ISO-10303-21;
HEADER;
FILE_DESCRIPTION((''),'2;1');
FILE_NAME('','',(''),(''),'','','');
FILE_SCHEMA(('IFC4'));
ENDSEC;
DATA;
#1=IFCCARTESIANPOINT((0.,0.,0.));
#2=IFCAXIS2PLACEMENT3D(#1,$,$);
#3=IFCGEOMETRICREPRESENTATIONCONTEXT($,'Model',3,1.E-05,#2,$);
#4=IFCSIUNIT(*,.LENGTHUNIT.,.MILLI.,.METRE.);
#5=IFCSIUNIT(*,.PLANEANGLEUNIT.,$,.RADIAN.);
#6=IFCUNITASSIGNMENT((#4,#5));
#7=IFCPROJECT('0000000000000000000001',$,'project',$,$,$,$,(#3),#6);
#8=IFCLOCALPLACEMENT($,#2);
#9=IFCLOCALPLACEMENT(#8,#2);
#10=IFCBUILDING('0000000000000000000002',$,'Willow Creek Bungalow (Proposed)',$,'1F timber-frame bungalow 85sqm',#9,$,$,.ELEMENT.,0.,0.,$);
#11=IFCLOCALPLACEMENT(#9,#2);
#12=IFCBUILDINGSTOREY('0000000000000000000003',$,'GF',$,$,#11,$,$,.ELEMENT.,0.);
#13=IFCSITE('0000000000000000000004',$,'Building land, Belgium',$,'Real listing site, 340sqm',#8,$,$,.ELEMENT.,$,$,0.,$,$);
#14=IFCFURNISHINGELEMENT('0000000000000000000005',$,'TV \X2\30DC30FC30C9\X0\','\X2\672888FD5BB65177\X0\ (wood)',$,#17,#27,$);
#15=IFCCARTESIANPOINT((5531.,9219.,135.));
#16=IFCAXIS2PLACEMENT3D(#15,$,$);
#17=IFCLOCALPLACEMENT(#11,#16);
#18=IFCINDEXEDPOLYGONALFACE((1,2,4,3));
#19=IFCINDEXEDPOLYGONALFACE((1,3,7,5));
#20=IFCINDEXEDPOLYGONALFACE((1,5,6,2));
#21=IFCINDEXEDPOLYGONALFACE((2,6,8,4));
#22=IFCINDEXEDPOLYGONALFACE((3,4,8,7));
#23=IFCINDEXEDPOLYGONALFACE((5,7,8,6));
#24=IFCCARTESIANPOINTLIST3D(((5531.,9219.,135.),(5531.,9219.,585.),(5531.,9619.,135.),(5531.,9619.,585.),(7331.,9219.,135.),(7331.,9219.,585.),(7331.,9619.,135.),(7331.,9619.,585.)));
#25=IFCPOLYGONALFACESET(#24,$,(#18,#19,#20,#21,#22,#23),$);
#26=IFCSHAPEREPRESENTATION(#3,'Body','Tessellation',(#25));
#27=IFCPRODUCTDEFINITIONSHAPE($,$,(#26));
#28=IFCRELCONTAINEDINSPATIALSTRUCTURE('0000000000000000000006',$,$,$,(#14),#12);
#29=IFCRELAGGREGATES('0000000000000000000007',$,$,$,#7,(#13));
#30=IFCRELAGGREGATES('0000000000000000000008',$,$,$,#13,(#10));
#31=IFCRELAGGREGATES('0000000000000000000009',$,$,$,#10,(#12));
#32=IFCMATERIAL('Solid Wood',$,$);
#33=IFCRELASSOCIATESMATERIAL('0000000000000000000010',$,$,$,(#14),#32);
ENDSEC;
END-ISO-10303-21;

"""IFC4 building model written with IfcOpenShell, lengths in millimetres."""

from ifc_helpers import new_model, si_unit, frame, frame_2d, origin, place, context, project, spatial, rectangle, extrude, material, element, save


model = new_model("IFC4")

# Units and contexts
model_context = context("Model", 3, precision=1e-05, world=origin())
ifc_project = project(units=[si_unit("LENGTHUNIT", "METRE", prefix="MILLI"), si_unit("PLANEANGLEUNIT", "RADIAN")], contexts=[model_context])

# Site, building, storey
site_placement = place(None, origin())
site = spatial("IfcSite", under=ifc_project, at=site_placement, Name="Building land, Belgium", ObjectType="Real listing site, 340sqm", CompositionType="ELEMENT", RefElevation=0.0)
building_placement = place(site_placement, origin())
building = spatial("IfcBuilding", under=site, at=building_placement, Name="Willow Creek Bungalow (Proposed)", ObjectType="1F timber-frame bungalow 85sqm", CompositionType="ELEMENT", ElevationOfRefHeight=0.0, ElevationOfTerrain=0.0)
storey_placement = place(building_placement, origin())
storey = spatial("IfcBuildingStorey", under=building, at=storey_placement, Name="GF", CompositionType="ELEMENT", Elevation=0.0)

# Shared definitions
ifc_material_1 = material(Name="Solid Wood")

# Furnishing element
furnishing_1_placement = place(storey_placement, frame((5531.0, 9219.0, 135.0)))
element("IfcFurnishingElement", 1, at=furnishing_1_placement, inside=storey, material=ifc_material_1, Name="TV ボード", Description="木製家具 (wood)", context=model_context, shape_type="SweptSolid", body=[
    extrude(rectangle(XDim=1800.0, YDim=400.0, at=frame_2d((900.0, 200.0))), frame((5531.0, 9219.0, 135.0)), (0.0, 0.0, 1.0), 450.0),
])

save(model, "model.ifc")
